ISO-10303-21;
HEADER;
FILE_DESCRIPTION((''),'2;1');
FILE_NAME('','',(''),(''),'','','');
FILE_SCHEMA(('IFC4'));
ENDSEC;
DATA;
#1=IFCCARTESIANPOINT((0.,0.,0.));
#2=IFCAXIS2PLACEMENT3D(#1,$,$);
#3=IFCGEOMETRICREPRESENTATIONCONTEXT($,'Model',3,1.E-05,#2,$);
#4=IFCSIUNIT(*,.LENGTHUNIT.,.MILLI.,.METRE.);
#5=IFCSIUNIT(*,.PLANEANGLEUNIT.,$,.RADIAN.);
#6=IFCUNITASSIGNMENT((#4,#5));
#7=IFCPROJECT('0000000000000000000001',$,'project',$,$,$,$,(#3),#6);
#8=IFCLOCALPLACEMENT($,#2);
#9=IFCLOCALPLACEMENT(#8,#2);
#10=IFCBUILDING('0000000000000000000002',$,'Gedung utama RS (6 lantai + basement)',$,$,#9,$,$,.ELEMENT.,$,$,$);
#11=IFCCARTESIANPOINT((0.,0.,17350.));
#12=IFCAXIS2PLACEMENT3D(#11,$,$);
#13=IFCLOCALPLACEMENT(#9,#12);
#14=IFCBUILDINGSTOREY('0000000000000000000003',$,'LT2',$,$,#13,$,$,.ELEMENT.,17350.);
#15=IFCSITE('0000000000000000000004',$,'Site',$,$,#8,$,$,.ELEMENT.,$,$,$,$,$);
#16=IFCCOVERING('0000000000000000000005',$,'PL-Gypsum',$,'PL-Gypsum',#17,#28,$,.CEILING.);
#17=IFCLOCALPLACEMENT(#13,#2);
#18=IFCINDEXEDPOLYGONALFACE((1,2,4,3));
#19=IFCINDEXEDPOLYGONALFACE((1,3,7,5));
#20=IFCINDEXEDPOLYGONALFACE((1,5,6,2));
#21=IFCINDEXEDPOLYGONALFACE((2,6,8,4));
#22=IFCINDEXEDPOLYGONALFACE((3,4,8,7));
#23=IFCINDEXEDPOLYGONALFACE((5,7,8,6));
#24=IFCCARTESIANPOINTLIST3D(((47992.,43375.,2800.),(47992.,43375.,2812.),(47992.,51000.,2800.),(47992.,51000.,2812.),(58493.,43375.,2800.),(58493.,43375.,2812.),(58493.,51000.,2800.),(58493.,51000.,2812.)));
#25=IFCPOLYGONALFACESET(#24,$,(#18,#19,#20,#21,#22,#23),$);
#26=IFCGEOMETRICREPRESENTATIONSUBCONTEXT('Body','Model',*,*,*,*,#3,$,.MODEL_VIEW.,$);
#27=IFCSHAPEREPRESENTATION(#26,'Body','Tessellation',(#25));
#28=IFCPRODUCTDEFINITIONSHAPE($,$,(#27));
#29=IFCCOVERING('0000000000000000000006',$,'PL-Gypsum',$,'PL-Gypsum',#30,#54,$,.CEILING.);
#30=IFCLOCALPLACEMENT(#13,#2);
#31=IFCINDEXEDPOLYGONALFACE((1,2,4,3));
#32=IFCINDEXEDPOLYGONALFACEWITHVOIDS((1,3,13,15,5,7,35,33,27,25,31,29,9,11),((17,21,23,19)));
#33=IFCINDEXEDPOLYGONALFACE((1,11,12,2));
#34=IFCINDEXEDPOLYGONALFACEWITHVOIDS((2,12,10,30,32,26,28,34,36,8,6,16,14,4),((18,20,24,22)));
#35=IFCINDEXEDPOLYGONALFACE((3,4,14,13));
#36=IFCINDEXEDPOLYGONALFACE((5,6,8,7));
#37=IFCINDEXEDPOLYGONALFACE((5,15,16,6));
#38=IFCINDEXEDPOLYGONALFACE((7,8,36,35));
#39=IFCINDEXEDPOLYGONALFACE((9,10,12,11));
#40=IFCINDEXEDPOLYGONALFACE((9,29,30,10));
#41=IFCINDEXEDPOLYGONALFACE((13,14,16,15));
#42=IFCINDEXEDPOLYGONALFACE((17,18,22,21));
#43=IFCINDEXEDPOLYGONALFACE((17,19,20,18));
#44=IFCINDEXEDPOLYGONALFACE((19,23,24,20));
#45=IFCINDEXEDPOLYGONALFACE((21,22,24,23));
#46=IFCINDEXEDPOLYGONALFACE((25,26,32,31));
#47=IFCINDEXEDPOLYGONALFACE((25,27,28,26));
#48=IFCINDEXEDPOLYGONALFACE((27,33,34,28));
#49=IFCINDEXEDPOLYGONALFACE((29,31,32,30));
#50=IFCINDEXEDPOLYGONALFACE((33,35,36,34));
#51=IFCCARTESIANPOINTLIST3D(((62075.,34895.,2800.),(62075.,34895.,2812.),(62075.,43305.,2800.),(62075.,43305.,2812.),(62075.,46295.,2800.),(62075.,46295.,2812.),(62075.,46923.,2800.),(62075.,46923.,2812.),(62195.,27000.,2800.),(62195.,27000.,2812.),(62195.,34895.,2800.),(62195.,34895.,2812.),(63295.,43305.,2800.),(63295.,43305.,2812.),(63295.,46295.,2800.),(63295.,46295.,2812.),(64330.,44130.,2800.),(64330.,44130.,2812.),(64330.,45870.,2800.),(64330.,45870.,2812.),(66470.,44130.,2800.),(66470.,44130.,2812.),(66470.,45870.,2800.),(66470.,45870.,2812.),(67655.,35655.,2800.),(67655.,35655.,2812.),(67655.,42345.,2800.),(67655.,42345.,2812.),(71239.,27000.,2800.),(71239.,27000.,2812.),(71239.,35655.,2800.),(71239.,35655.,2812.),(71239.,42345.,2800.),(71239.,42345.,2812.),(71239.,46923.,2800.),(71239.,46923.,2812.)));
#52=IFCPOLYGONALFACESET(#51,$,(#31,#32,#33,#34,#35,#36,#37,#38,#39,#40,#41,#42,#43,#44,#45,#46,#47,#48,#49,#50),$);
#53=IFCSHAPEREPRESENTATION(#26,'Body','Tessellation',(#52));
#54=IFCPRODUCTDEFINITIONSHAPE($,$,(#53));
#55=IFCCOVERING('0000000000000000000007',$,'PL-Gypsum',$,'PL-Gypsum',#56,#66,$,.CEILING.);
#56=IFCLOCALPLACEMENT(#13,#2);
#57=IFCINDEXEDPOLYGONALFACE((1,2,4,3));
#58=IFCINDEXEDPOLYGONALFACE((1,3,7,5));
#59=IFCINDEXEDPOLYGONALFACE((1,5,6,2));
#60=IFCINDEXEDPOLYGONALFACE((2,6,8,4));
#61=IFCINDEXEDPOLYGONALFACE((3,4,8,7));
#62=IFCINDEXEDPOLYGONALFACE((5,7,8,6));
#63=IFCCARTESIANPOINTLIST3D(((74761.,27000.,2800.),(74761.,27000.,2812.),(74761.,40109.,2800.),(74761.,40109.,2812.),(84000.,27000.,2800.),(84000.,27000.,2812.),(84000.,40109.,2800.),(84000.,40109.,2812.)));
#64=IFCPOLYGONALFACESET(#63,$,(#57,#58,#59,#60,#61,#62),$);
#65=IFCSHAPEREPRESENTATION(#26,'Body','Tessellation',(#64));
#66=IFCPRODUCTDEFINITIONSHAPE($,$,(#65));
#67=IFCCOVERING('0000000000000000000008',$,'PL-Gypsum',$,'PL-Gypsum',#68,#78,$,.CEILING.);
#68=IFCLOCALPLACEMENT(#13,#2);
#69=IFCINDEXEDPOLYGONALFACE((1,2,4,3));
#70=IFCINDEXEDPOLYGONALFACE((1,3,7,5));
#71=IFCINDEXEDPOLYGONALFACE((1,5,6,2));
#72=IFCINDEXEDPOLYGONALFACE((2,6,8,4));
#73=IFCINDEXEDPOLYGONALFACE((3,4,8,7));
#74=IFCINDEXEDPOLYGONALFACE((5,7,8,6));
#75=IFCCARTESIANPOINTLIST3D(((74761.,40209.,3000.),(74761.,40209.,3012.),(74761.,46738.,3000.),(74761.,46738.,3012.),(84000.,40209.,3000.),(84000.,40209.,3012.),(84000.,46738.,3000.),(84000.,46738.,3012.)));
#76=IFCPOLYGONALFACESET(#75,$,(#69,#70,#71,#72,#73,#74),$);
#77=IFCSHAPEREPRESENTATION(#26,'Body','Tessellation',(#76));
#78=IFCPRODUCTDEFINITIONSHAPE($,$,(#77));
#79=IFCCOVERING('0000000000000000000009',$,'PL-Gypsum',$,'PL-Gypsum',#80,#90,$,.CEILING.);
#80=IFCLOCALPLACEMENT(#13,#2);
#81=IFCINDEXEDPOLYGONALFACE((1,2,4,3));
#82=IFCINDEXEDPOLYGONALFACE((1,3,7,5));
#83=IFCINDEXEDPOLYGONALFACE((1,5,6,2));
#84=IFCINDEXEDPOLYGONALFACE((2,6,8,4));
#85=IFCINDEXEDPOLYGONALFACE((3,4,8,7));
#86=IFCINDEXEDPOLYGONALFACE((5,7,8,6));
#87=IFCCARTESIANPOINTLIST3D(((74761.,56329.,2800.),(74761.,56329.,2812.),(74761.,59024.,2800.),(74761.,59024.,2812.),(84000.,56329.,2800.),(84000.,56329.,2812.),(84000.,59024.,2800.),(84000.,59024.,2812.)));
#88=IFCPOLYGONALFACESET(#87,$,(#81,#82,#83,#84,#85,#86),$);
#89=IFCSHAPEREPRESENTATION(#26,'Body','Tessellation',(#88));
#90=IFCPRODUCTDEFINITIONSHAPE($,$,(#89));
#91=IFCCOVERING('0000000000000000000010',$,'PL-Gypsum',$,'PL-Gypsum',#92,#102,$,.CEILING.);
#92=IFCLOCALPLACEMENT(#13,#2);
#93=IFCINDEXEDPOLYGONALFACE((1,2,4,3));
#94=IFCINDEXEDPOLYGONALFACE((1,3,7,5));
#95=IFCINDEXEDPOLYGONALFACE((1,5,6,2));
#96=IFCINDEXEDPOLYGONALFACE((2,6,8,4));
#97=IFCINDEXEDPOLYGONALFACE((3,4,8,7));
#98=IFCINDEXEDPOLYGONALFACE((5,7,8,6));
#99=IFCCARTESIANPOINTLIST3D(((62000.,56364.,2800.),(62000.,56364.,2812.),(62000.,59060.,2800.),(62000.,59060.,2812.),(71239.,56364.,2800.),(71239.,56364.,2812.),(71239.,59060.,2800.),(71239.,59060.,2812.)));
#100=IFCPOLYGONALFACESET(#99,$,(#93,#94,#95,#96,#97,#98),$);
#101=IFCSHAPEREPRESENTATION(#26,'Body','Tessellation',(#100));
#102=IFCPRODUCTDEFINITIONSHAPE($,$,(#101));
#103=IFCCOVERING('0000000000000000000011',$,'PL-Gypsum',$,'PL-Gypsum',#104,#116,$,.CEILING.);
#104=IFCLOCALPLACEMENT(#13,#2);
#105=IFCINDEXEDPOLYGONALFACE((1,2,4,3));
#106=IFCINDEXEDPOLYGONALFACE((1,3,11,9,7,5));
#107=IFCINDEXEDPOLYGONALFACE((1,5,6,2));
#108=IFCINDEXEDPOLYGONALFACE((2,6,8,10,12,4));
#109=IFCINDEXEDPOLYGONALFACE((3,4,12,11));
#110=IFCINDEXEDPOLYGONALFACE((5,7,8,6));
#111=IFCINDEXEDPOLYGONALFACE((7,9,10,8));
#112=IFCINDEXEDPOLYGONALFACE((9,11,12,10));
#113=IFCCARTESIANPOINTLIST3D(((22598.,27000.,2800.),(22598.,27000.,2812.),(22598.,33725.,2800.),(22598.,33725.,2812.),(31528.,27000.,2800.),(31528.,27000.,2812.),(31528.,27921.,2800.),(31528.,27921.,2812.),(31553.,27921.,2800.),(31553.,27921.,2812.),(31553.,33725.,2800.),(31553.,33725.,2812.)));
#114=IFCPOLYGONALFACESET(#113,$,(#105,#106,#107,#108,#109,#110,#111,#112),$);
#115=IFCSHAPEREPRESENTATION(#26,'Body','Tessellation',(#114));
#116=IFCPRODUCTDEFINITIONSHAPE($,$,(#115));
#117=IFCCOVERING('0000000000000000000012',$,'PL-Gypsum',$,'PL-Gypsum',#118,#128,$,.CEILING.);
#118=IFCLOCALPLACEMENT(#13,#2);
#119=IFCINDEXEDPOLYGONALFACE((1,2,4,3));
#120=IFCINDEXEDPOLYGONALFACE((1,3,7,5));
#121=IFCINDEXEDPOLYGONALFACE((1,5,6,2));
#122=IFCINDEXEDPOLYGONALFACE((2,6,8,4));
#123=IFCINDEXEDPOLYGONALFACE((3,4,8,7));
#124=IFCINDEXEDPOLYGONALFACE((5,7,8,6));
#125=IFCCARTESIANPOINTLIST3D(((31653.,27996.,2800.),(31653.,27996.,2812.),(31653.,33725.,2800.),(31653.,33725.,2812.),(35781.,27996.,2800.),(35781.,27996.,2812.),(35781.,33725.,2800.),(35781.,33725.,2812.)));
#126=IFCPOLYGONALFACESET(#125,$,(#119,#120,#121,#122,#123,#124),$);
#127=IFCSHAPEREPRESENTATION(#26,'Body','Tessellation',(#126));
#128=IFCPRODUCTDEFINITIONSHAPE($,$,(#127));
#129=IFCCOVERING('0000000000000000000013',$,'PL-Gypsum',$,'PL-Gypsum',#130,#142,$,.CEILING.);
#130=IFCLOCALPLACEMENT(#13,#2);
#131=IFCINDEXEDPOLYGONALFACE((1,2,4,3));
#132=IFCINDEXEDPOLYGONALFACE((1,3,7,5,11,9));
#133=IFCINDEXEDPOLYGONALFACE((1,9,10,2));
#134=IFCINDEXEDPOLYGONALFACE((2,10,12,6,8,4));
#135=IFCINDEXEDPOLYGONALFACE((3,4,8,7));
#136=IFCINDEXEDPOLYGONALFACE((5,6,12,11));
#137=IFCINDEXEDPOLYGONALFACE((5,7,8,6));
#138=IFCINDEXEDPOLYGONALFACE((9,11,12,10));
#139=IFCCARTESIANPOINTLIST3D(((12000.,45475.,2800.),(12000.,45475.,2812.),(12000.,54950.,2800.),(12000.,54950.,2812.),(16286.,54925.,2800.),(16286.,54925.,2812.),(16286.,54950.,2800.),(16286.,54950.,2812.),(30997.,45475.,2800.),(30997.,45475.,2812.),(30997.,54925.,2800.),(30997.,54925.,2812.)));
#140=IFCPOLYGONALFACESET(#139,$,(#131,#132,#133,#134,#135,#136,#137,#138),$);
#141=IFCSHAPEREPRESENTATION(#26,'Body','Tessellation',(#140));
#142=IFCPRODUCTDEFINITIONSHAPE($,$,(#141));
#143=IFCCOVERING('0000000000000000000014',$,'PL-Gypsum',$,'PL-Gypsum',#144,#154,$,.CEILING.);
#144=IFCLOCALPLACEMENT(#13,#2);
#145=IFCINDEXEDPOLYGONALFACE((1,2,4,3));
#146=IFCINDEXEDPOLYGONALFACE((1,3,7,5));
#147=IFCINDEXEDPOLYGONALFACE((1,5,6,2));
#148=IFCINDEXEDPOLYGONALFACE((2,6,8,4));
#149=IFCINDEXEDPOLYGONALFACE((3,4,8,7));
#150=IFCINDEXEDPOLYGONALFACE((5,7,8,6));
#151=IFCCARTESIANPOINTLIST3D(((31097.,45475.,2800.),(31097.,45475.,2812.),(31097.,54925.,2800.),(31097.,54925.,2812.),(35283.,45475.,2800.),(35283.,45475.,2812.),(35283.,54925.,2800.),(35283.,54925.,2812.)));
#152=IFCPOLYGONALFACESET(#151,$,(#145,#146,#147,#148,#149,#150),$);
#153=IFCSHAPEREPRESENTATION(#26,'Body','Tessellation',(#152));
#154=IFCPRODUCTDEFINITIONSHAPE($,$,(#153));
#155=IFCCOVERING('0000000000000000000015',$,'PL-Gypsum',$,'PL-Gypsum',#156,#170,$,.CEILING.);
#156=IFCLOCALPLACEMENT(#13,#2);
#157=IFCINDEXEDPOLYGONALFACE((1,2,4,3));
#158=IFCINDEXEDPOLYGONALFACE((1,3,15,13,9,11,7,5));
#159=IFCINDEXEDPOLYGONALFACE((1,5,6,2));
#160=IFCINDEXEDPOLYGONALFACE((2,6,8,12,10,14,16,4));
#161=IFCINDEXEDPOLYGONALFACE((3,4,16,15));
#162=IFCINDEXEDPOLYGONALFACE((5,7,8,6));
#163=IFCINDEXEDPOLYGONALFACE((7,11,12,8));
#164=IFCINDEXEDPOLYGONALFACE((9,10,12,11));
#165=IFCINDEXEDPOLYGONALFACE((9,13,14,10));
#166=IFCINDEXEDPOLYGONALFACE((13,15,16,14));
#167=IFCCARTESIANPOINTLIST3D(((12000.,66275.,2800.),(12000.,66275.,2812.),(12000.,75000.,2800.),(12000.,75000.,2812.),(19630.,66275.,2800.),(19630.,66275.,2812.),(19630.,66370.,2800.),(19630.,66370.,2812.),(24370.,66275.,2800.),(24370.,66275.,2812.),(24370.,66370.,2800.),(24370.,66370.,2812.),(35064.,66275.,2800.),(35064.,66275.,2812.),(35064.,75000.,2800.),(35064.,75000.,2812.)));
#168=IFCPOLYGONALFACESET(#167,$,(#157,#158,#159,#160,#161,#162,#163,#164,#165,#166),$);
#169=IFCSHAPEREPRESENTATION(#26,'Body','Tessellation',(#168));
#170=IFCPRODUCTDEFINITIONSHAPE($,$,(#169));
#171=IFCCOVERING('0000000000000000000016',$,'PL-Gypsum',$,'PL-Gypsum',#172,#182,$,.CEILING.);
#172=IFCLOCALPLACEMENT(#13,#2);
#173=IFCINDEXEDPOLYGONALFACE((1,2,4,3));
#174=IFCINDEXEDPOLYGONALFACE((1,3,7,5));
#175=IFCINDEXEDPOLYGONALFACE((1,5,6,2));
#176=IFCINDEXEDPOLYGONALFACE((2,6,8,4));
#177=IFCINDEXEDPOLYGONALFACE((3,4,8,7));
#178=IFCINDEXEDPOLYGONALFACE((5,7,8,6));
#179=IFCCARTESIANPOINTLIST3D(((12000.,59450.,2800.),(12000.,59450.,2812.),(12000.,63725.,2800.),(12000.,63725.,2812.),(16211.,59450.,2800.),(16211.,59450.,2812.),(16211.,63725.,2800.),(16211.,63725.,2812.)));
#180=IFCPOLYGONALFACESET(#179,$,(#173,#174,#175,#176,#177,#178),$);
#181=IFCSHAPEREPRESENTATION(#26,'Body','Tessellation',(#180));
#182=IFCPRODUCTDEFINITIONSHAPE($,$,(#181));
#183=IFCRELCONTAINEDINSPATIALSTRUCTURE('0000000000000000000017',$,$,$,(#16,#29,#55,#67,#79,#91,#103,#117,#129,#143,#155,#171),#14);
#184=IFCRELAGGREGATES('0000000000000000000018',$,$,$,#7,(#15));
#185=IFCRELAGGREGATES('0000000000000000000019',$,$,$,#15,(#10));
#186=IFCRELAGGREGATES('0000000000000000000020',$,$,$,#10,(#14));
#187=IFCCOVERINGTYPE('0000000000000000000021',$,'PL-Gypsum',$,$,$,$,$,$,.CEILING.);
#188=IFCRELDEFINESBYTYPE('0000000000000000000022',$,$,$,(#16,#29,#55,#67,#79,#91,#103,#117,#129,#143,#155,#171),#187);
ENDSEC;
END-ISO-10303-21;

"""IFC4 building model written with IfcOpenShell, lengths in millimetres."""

from ifc_helpers import new_model, si_unit, frame, origin, place, context, subcontext, project, spatial, polyline, outline, extrude, type_object, element, save


model = new_model("IFC4")

# Units and contexts
model_context = context("Model", 3, precision=1e-05, world=origin())
body_context = subcontext(model_context, "Body", "Model", "MODEL_VIEW")
ifc_project = project(units=[si_unit("LENGTHUNIT", "METRE", prefix="MILLI"), si_unit("PLANEANGLEUNIT", "RADIAN")], contexts=[model_context])

# Site, building, storey
site_placement = place(None, origin())
site = spatial("IfcSite", under=ifc_project, at=site_placement, Name="Site", CompositionType="ELEMENT")
building_placement = place(site_placement, origin())
building = spatial("IfcBuilding", under=site, at=building_placement, Name="Gedung utama RS (6 lantai + basement)", CompositionType="ELEMENT")
storey_placement = place(building_placement, frame((0.0, 0.0, 17350.0)))
storey = spatial("IfcBuildingStorey", under=building, at=storey_placement, Name="LT2", CompositionType="ELEMENT", Elevation=17350.0)

# Coverings
covering_type = type_object("IfcCoveringType", Name="PL-Gypsum", PredefinedType="CEILING")
covering_1_placement = place(storey_placement, origin())
element("IfcCovering", 1, at=covering_1_placement, inside=storey, type_object=covering_type, Name="PL-Gypsum", ObjectType="PL-Gypsum", PredefinedType="CEILING", context=body_context, shape_type="SweptSolid", body=[
    extrude(outline(polyline([(47992.0, 43375.0), (58493.0, 43375.0), (58493.0, 51000.0), (47992.0, 51000.0), (47992.0, 43375.0)])), frame((0.0, 0.0, 2800.0)), (0.0, 0.0, 1.0), 12.0),
])
covering_2_placement = place(storey_placement, origin())
element("IfcCovering", 2, at=covering_2_placement, inside=storey, type_object=covering_type, Name="PL-Gypsum", ObjectType="PL-Gypsum", PredefinedType="CEILING", context=body_context, shape_type="SweptSolid", body=[
    extrude(outline(polyline([(62195.0, 27000.0), (71239.0, 27000.0), (71239.0, 35655.0), (67655.0, 35655.0), (67655.0, 42345.0), (71239.0, 42345.0), (71239.0, 46923.0), (62075.0, 46923.0), (62075.0, 46295.0), (63295.0, 46295.0), (63295.0, 43305.0), (62075.0, 43305.0), (62075.0, 34895.0), (62195.0, 34895.0), (62195.0, 27000.0)]), holes=[polyline([(64330.0, 44130.0), (64330.0, 45870.0), (66470.0, 45870.0), (66470.0, 44130.0), (64330.0, 44130.0)])]), frame((0.0, 0.0, 2800.0)), (0.0, 0.0, 1.0), 12.0),
])
covering_3_placement = place(storey_placement, origin())
element("IfcCovering", 3, at=covering_3_placement, inside=storey, type_object=covering_type, Name="PL-Gypsum", ObjectType="PL-Gypsum", PredefinedType="CEILING", context=body_context, shape_type="SweptSolid", body=[
    extrude(outline(polyline([(74761.0, 27000.0), (84000.0, 27000.0), (84000.0, 40109.0), (74761.0, 40109.0), (74761.0, 27000.0)])), frame((0.0, 0.0, 2800.0)), (0.0, 0.0, 1.0), 12.0),
])
covering_4_placement = place(storey_placement, origin())
element("IfcCovering", 4, at=covering_4_placement, inside=storey, type_object=covering_type, Name="PL-Gypsum", ObjectType="PL-Gypsum", PredefinedType="CEILING", context=body_context, shape_type="SweptSolid", body=[
    extrude(outline(polyline([(74761.0, 40209.0), (84000.0, 40209.0), (84000.0, 46738.0), (74761.0, 46738.0), (74761.0, 40209.0)])), frame((0.0, 0.0, 3000.0)), (0.0, 0.0, 1.0), 12.0),
])
covering_5_placement = place(storey_placement, origin())
element("IfcCovering", 5, at=covering_5_placement, inside=storey, type_object=covering_type, Name="PL-Gypsum", ObjectType="PL-Gypsum", PredefinedType="CEILING", context=body_context, shape_type="SweptSolid", body=[
    extrude(outline(polyline([(74761.0, 56329.0), (84000.0, 56329.0), (84000.0, 59024.0), (74761.0, 59024.0), (74761.0, 56329.0)])), frame((0.0, 0.0, 2800.0)), (0.0, 0.0, 1.0), 12.0),
])
covering_6_placement = place(storey_placement, origin())
element("IfcCovering", 6, at=covering_6_placement, inside=storey, type_object=covering_type, Name="PL-Gypsum", ObjectType="PL-Gypsum", PredefinedType="CEILING", context=body_context, shape_type="SweptSolid", body=[
    extrude(outline(polyline([(62000.0, 56364.0), (71239.0, 56364.0), (71239.0, 59060.0), (62000.0, 59060.0), (62000.0, 56364.0)])), frame((0.0, 0.0, 2800.0)), (0.0, 0.0, 1.0), 12.0),
])
covering_7_placement = place(storey_placement, origin())
element("IfcCovering", 7, at=covering_7_placement, inside=storey, type_object=covering_type, Name="PL-Gypsum", ObjectType="PL-Gypsum", PredefinedType="CEILING", context=body_context, shape_type="SweptSolid", body=[
    extrude(outline(polyline([(22598.0, 27000.0), (31528.0, 27000.0), (31528.0, 27921.0), (31553.0, 27921.0), (31553.0, 33725.0), (22598.0, 33725.0), (22598.0, 27000.0)])), frame((0.0, 0.0, 2800.0)), (0.0, 0.0, 1.0), 12.0),
])
covering_8_placement = place(storey_placement, origin())
element("IfcCovering", 8, at=covering_8_placement, inside=storey, type_object=covering_type, Name="PL-Gypsum", ObjectType="PL-Gypsum", PredefinedType="CEILING", context=body_context, shape_type="SweptSolid", body=[
    extrude(outline(polyline([(31653.0, 27996.0), (35781.0, 27996.0), (35781.0, 33725.0), (31653.0, 33725.0), (31653.0, 27996.0)])), frame((0.0, 0.0, 2800.0)), (0.0, 0.0, 1.0), 12.0),
])
covering_9_placement = place(storey_placement, origin())
element("IfcCovering", 9, at=covering_9_placement, inside=storey, type_object=covering_type, Name="PL-Gypsum", ObjectType="PL-Gypsum", PredefinedType="CEILING", context=body_context, shape_type="SweptSolid", body=[
    extrude(outline(polyline([(12000.0, 45475.0), (30997.0, 45475.0), (30997.0, 54925.0), (16286.0, 54925.0), (16286.0, 54950.0), (12000.0, 54950.0), (12000.0, 45475.0)])), frame((0.0, 0.0, 2800.0)), (0.0, 0.0, 1.0), 12.0),
])
covering_10_placement = place(storey_placement, origin())
element("IfcCovering", 10, at=covering_10_placement, inside=storey, type_object=covering_type, Name="PL-Gypsum", ObjectType="PL-Gypsum", PredefinedType="CEILING", context=body_context, shape_type="SweptSolid", body=[
    extrude(outline(polyline([(31097.0, 45475.0), (35283.0, 45475.0), (35283.0, 54925.0), (31097.0, 54925.0), (31097.0, 45475.0)])), frame((0.0, 0.0, 2800.0)), (0.0, 0.0, 1.0), 12.0),
])
covering_11_placement = place(storey_placement, origin())
element("IfcCovering", 11, at=covering_11_placement, inside=storey, type_object=covering_type, Name="PL-Gypsum", ObjectType="PL-Gypsum", PredefinedType="CEILING", context=body_context, shape_type="SweptSolid", body=[
    extrude(outline(polyline([(12000.0, 66275.0), (19630.0, 66275.0), (19630.0, 66370.0), (24370.0, 66370.0), (24370.0, 66275.0), (35064.0, 66275.0), (35064.0, 75000.0), (12000.0, 75000.0), (12000.0, 66275.0)])), frame((0.0, 0.0, 2800.0)), (0.0, 0.0, 1.0), 12.0),
])
covering_12_placement = place(storey_placement, origin())
element("IfcCovering", 12, at=covering_12_placement, inside=storey, type_object=covering_type, Name="PL-Gypsum", ObjectType="PL-Gypsum", PredefinedType="CEILING", context=body_context, shape_type="SweptSolid", body=[
    extrude(outline(polyline([(12000.0, 59450.0), (16211.0, 59450.0), (16211.0, 63725.0), (12000.0, 63725.0), (12000.0, 59450.0)])), frame((0.0, 0.0, 2800.0)), (0.0, 0.0, 1.0), 12.0),
])

save(model, "model.ifc")
